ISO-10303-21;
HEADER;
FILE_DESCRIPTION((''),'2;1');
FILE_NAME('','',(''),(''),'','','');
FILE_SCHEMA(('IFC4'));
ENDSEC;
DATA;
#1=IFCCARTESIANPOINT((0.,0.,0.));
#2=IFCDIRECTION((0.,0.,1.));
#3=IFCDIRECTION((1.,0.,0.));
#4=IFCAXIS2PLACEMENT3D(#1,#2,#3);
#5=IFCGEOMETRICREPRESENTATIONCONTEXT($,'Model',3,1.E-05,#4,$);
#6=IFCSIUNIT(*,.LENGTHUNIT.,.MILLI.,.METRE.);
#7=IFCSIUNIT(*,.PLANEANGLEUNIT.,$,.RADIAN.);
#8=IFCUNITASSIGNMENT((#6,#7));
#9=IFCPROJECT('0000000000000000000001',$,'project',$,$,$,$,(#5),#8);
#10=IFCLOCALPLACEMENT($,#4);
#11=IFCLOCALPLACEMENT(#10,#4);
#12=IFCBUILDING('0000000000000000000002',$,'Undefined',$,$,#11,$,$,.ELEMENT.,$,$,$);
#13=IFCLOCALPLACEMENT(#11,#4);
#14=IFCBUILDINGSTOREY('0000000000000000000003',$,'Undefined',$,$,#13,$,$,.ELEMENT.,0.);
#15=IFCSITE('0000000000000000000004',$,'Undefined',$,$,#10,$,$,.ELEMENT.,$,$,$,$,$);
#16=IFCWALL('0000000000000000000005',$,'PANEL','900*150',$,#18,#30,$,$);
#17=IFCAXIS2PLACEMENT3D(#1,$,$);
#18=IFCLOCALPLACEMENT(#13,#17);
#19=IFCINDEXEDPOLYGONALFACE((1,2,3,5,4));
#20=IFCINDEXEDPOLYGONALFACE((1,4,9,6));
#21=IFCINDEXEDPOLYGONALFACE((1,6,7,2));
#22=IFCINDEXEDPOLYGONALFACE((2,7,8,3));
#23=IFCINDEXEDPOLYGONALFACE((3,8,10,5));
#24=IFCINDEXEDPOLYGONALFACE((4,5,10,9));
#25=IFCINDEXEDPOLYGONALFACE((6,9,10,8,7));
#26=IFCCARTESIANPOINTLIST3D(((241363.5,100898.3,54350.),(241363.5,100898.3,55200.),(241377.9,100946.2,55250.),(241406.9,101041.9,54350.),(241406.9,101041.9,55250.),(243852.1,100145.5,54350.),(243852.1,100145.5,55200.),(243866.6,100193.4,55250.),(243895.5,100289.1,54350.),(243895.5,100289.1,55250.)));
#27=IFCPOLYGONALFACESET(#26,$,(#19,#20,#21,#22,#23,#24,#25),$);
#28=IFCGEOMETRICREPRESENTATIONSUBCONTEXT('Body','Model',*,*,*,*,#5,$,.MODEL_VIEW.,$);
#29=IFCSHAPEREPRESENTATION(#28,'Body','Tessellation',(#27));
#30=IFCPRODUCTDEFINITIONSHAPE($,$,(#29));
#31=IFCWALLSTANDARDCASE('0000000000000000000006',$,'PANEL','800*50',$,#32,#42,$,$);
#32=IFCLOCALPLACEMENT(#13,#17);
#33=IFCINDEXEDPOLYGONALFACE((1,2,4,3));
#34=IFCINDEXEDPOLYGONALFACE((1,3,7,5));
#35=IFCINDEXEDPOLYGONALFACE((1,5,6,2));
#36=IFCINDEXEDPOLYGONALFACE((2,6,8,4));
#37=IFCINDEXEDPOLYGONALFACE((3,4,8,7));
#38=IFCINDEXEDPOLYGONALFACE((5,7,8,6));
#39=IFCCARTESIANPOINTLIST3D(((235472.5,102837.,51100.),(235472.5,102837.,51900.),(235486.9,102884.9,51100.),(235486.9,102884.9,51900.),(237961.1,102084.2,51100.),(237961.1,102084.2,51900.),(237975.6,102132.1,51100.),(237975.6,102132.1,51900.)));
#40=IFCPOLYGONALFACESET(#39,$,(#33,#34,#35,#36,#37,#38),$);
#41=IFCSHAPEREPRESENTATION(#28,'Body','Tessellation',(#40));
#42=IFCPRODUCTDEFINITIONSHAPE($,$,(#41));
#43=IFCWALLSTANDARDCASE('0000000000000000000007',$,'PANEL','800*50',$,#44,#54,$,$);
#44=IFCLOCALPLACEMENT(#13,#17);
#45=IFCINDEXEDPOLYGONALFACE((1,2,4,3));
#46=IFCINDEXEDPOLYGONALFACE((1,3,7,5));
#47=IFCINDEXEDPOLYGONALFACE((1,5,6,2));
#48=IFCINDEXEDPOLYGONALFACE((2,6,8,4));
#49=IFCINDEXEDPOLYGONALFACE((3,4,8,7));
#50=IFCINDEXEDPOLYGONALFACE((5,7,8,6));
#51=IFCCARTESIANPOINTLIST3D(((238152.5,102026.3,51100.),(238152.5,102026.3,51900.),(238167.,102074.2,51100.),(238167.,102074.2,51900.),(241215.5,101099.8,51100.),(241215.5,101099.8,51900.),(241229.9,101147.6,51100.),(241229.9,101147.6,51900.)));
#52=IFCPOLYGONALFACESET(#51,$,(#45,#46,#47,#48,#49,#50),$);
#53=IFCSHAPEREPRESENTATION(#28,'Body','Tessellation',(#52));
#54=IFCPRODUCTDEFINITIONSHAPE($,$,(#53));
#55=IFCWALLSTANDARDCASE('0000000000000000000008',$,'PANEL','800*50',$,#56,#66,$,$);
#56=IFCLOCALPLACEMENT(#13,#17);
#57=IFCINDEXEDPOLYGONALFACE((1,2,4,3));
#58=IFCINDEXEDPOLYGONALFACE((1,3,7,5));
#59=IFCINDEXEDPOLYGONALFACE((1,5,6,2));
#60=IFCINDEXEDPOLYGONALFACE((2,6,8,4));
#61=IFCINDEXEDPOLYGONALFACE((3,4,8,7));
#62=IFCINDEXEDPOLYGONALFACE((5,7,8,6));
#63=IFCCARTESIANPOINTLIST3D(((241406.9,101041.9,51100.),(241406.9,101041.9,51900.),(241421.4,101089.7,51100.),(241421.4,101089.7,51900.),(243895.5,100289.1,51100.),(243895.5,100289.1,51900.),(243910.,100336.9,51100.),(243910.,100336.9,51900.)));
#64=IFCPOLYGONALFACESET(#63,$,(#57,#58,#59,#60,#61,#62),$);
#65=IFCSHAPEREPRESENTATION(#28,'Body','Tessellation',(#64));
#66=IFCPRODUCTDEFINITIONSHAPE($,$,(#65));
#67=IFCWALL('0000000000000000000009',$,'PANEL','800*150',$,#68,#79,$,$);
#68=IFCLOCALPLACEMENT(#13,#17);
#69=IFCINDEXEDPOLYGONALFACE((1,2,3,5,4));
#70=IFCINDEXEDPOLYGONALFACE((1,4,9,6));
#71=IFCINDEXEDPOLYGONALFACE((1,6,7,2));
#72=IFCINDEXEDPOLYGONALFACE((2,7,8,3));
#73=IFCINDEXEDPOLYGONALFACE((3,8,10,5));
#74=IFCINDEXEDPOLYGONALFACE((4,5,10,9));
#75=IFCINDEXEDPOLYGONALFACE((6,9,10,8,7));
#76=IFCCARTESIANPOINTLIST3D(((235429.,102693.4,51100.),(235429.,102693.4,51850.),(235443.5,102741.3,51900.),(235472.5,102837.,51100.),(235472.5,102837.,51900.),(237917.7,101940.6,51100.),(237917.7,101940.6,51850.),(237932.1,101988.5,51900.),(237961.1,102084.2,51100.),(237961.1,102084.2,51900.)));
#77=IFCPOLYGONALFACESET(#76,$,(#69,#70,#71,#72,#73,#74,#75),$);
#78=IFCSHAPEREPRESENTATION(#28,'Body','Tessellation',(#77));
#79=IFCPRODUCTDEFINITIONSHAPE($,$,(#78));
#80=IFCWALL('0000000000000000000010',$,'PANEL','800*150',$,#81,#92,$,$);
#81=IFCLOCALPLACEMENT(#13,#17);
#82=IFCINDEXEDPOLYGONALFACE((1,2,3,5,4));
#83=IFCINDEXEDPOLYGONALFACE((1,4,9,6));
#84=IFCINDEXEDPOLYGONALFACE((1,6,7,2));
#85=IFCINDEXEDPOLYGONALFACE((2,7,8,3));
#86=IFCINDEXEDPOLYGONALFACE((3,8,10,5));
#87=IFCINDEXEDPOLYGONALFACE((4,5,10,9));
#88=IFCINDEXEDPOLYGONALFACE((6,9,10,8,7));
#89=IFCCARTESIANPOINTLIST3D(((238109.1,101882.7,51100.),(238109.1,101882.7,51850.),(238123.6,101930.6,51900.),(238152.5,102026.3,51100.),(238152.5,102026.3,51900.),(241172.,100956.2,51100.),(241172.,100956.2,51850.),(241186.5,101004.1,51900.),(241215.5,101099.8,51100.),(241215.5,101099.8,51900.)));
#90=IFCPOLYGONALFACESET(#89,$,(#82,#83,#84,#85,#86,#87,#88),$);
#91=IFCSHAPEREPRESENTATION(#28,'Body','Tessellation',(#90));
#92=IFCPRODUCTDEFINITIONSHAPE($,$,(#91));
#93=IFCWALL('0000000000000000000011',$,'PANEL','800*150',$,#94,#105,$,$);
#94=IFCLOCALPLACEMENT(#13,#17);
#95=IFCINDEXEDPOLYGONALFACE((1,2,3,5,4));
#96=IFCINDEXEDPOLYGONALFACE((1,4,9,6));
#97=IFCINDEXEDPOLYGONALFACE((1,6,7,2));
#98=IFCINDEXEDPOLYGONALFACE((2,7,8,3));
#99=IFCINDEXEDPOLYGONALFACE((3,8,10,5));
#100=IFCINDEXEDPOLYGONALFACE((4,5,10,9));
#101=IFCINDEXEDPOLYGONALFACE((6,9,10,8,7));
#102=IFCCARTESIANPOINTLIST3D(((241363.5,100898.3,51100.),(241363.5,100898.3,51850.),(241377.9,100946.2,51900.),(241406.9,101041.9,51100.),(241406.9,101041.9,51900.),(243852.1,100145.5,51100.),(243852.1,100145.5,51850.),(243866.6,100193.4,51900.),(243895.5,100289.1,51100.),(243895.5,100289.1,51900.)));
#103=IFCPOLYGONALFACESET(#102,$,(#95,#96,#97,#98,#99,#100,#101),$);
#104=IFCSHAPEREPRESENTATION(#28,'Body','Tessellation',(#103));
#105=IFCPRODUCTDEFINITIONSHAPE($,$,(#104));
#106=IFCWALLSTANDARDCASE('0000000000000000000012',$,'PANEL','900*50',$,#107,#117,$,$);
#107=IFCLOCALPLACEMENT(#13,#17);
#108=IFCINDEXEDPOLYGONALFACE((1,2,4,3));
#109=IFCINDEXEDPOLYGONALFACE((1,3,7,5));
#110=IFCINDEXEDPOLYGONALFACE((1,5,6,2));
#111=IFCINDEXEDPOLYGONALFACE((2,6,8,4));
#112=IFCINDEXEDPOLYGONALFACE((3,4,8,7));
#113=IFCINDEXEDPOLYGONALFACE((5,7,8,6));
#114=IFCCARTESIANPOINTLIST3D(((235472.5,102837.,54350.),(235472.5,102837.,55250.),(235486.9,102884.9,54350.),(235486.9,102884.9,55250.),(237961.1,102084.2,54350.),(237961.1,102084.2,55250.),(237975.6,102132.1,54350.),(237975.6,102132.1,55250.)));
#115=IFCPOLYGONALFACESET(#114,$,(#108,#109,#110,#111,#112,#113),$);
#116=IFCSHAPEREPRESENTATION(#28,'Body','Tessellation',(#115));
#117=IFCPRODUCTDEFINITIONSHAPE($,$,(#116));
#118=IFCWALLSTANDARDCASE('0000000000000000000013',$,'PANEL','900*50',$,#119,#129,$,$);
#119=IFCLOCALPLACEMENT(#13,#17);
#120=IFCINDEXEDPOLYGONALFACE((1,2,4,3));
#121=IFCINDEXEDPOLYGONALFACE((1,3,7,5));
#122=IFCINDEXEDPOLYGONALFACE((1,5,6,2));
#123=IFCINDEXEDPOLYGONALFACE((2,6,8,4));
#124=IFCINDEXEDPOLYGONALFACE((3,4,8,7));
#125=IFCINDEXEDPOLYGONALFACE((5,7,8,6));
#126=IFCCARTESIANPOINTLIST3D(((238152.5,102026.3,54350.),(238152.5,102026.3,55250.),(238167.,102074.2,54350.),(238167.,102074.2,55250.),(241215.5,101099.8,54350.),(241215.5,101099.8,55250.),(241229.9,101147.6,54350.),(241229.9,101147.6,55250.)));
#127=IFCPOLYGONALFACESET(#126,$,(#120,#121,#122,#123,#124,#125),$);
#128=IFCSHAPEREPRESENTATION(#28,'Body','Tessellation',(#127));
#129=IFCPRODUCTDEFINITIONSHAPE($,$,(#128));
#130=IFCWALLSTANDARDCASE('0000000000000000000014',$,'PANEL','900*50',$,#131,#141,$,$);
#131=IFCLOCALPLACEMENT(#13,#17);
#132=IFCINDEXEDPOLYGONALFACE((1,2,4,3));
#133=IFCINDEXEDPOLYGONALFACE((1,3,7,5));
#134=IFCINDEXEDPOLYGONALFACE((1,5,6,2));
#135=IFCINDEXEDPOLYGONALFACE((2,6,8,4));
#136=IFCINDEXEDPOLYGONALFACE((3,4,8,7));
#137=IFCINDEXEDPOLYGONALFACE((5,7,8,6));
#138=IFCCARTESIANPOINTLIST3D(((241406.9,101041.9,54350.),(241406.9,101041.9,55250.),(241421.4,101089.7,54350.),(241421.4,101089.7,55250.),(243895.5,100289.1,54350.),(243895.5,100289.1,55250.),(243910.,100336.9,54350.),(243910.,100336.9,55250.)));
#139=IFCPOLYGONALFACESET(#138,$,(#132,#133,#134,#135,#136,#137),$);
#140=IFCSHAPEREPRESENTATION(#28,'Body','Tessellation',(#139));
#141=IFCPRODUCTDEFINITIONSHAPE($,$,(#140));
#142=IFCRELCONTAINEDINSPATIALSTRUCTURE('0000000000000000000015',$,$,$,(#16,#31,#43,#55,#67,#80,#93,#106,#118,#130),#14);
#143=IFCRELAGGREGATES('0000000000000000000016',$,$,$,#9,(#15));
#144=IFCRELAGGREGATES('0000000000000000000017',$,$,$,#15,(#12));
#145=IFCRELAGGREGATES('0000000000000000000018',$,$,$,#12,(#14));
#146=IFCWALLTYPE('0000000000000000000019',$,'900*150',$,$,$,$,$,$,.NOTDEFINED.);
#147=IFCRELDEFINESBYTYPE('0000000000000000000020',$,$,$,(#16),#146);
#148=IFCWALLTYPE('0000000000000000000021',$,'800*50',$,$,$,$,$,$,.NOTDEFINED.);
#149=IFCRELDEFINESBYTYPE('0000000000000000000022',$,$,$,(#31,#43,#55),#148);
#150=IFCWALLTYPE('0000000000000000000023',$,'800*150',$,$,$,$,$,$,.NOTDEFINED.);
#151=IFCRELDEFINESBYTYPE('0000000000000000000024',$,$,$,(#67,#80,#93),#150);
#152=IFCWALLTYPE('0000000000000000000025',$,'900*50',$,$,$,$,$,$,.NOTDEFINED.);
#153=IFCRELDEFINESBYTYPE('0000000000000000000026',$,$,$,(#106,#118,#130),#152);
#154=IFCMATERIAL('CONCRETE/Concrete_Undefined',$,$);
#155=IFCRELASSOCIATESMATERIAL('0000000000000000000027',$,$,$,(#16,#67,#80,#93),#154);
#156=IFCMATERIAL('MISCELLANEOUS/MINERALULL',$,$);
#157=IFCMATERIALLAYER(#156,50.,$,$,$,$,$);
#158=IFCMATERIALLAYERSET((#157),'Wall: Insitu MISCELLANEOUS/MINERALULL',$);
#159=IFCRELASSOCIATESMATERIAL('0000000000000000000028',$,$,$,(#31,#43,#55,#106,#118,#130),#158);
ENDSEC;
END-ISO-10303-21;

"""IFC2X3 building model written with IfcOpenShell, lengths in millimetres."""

from ifc_helpers import new_model, si_unit, frame, frame_2d, origin_with_axes, place, context, subcontext, project, spatial, rectangle, extrude, clip, halfspace, material, layer, layer_set, layer_usage, type_object, element, save


model = new_model("IFC2X3")

# Units and contexts
model_context = context("Model", 3, precision=1e-05, world=origin_with_axes())
body_context = subcontext(model_context, "Body", "Model", "MODEL_VIEW")
ifc_project = project(units=[si_unit("LENGTHUNIT", "METRE", prefix="MILLI"), si_unit("PLANEANGLEUNIT", "RADIAN")], contexts=[model_context])

# Site, building, storey
site_placement = place(None, origin_with_axes())
site = spatial("IfcSite", under=ifc_project, at=site_placement, Name="Undefined", CompositionType="ELEMENT")
building_placement = place(site_placement, origin_with_axes())
building = spatial("IfcBuilding", under=site, at=building_placement, Name="Undefined", CompositionType="ELEMENT")
storey_placement = place(building_placement, origin_with_axes())
storey = spatial("IfcBuildingStorey", under=building, at=storey_placement, Name="Undefined", CompositionType="ELEMENT", Elevation=0.0)

# Shared definitions
ifc_material_1 = material(Name="CONCRETE/Concrete_Undefined")

# Walls
wall_type_1 = type_object("IfcWallType", Name="900*150", PredefinedType="NOTDEFINED")
wall_1_placement = place(storey_placement, frame((241385.2, 100970.1, 54350.0), z_axis=(0.0, 0.0, 1.0), x_axis=(0.957166, -0.289539, 0.0)))
element("IfcWall", 1, at=wall_1_placement, inside=storey, type_object=wall_type_1, material=ifc_material_1, Name="PANEL", Description="900*150", context=body_context, shape_type="Clipping", body=[
    clip(extrude(rectangle(XDim=2600.0, YDim=150.0, at=frame_2d((0.0, 1300.0), x_axis=(0.0, -1.0))), frame((0.0, 0.0, 0.0), z_axis=(0.0, 0.0, 1.0), x_axis=(0.0, -1.0, 0.0)), (0.0, 0.0, 1.0), 900.0), halfspace(frame((2600.0, 75.0, 1000.0), z_axis=(0.000001, -0.707072, 0.707141), x_axis=(0.0, -0.707141, -0.707072)), False)),
])
ifc_material_2 = material(Name="MISCELLANEOUS/MINERALULL")
ifc_layer = layer(ifc_material_2, 50.0)
ifc_layer_set = layer_set([ifc_layer], Name="Wall: Insitu MISCELLANEOUS/MINERALULL")
ifc_layer_usage_1 = layer_usage(ifc_layer_set, "AXIS2", "POSITIVE", -25.0)
wall_type_2 = type_object("IfcWallType", Name="800*50", PredefinedType="NOTDEFINED")
wall_2_placement = place(storey_placement, frame((235479.7, 102860.9, 51100.0), z_axis=(0.0, 0.0, 1.0), x_axis=(0.957166, -0.289539, 0.0)))
element("IfcWallStandardCase", 2, at=wall_2_placement, inside=storey, type_object=wall_type_2, material=ifc_layer_usage_1, Name="PANEL", Description="800*50", context=body_context, shape_type="SweptSolid", body=[
    extrude(rectangle(XDim=2600.0, YDim=50.0, at=frame_2d((0.0, 1300.0), x_axis=(0.0, -1.0))), frame((0.0, 0.0, 0.0), z_axis=(0.0, 0.0, 1.0), x_axis=(0.0, -1.0, 0.0)), (0.0, 0.0, 1.0), 800.0),
])
ifc_layer_usage_2 = layer_usage(ifc_layer_set, "AXIS2", "POSITIVE", -25.0)
wall_3_placement = place(storey_placement, frame((238159.8, 102050.2, 51100.0), z_axis=(0.0, 0.0, 1.0), x_axis=(0.957166, -0.289539, 0.0)))
element("IfcWallStandardCase", 3, at=wall_3_placement, inside=storey, type_object=wall_type_2, material=ifc_layer_usage_2, Name="PANEL", Description="800*50", context=body_context, shape_type="SweptSolid", body=[
    extrude(rectangle(XDim=3200.0, YDim=50.0, at=frame_2d((0.0, 1600.0), x_axis=(0.0, -1.0))), frame((0.0, 0.0, 0.0), z_axis=(0.0, 0.0, 1.0), x_axis=(0.0, -1.0, 0.0)), (0.0, 0.0, 1.0), 800.0),
])
ifc_layer_usage_3 = layer_usage(ifc_layer_set, "AXIS2", "POSITIVE", -25.0)
wall_4_placement = place(storey_placement, frame((241414.1, 101065.8, 51100.0), z_axis=(0.0, 0.0, 1.0), x_axis=(0.957166, -0.289539, 0.0)))
element("IfcWallStandardCase", 4, at=wall_4_placement, inside=storey, type_object=wall_type_2, material=ifc_layer_usage_3, Name="PANEL", Description="800*50", context=body_context, shape_type="SweptSolid", body=[
    extrude(rectangle(XDim=2600.0, YDim=50.0, at=frame_2d((0.0, 1300.0), x_axis=(0.0, -1.0))), frame((0.0, 0.0, 0.0), z_axis=(0.0, 0.0, 1.0), x_axis=(0.0, -1.0, 0.0)), (0.0, 0.0, 1.0), 800.0),
])
wall_type_3 = type_object("IfcWallType", Name="800*150", PredefinedType="NOTDEFINED")
wall_5_placement = place(storey_placement, frame((235450.7, 102765.2, 51100.0), z_axis=(0.0, 0.0, 1.0), x_axis=(0.957166, -0.289539, 0.0)))
element("IfcWall", 5, at=wall_5_placement, inside=storey, type_object=wall_type_3, material=ifc_material_1, Name="PANEL", Description="800*150", context=body_context, shape_type="Clipping", body=[
    clip(extrude(rectangle(XDim=2600.0, YDim=150.0, at=frame_2d((0.0, 1300.0), x_axis=(0.0, -1.0))), frame((0.0, 0.0, 0.0), z_axis=(0.0, 0.0, 1.0), x_axis=(0.0, -1.0, 0.0)), (0.0, 0.0, 1.0), 800.0), halfspace(frame((2600.0, 75.0, 900.0), z_axis=(0.000001, -0.707072, 0.707141), x_axis=(0.0, -0.707141, -0.707072)), False)),
])
wall_6_placement = place(storey_placement, frame((238130.8, 101954.5, 51100.0), z_axis=(0.0, 0.0, 1.0), x_axis=(0.957166, -0.289539, 0.0)))
element("IfcWall", 6, at=wall_6_placement, inside=storey, type_object=wall_type_3, material=ifc_material_1, Name="PANEL", Description="800*150", context=body_context, shape_type="Clipping", body=[
    clip(extrude(rectangle(XDim=3200.0, YDim=150.0, at=frame_2d((0.0, 1600.0), x_axis=(0.0, -1.0))), frame((0.0, 0.0, 0.0), z_axis=(0.0, 0.0, 1.0), x_axis=(0.0, -1.0, 0.0)), (0.0, 0.0, 1.0), 800.0), halfspace(frame((3200.0, 75.0, 900.0), z_axis=(0.000001, -0.707072, 0.707141), x_axis=(0.0, -0.707141, -0.707072)), False)),
])
wall_7_placement = place(storey_placement, frame((241385.2, 100970.1, 51100.0), z_axis=(0.0, 0.0, 1.0), x_axis=(0.957166, -0.289539, 0.0)))
element("IfcWall", 7, at=wall_7_placement, inside=storey, type_object=wall_type_3, material=ifc_material_1, Name="PANEL", Description="800*150", context=body_context, shape_type="Clipping", body=[
    clip(extrude(rectangle(XDim=2600.0, YDim=150.0, at=frame_2d((0.0, 1300.0), x_axis=(0.0, -1.0))), frame((0.0, 0.0, 0.0), z_axis=(0.0, 0.0, 1.0), x_axis=(0.0, -1.0, 0.0)), (0.0, 0.0, 1.0), 800.0), halfspace(frame((2600.0, 75.0, 900.0), z_axis=(0.000001, -0.707072, 0.707141), x_axis=(0.0, -0.707141, -0.707072)), False)),
])
ifc_layer_usage_4 = layer_usage(ifc_layer_set, "AXIS2", "POSITIVE", -25.0)
wall_type_4 = type_object("IfcWallType", Name="900*50", PredefinedType="NOTDEFINED")
wall_8_placement = place(storey_placement, frame((235479.7, 102860.9, 54350.0), z_axis=(0.0, 0.0, 1.0), x_axis=(0.957166, -0.289539, 0.0)))
element("IfcWallStandardCase", 8, at=wall_8_placement, inside=storey, type_object=wall_type_4, material=ifc_layer_usage_4, Name="PANEL", Description="900*50", context=body_context, shape_type="SweptSolid", body=[
    extrude(rectangle(XDim=2600.0, YDim=50.0, at=frame_2d((0.0, 1300.0), x_axis=(0.0, -1.0))), frame((0.0, 0.0, 0.0), z_axis=(0.0, 0.0, 1.0), x_axis=(0.0, -1.0, 0.0)), (0.0, 0.0, 1.0), 900.0),
])
ifc_layer_usage_5 = layer_usage(ifc_layer_set, "AXIS2", "POSITIVE", -25.0)
wall_9_placement = place(storey_placement, frame((238159.8, 102050.2, 54350.0), z_axis=(0.0, 0.0, 1.0), x_axis=(0.957166, -0.289539, 0.0)))
element("IfcWallStandardCase", 9, at=wall_9_placement, inside=storey, type_object=wall_type_4, material=ifc_layer_usage_5, Name="PANEL", Description="900*50", context=body_context, shape_type="SweptSolid", body=[
    extrude(rectangle(XDim=3200.0, YDim=50.0, at=frame_2d((0.0, 1600.0), x_axis=(0.0, -1.0))), frame((0.0, 0.0, 0.0), z_axis=(0.0, 0.0, 1.0), x_axis=(0.0, -1.0, 0.0)), (0.0, 0.0, 1.0), 900.0),
])
ifc_layer_usage_6 = layer_usage(ifc_layer_set, "AXIS2", "POSITIVE", -25.0)
wall_10_placement = place(storey_placement, frame((241414.1, 101065.8, 54350.0), z_axis=(0.0, 0.0, 1.0), x_axis=(0.957166, -0.289539, 0.0)))
element("IfcWallStandardCase", 10, at=wall_10_placement, inside=storey, type_object=wall_type_4, material=ifc_layer_usage_6, Name="PANEL", Description="900*50", context=body_context, shape_type="SweptSolid", body=[
    extrude(rectangle(XDim=2600.0, YDim=50.0, at=frame_2d((0.0, 1300.0), x_axis=(0.0, -1.0))), frame((0.0, 0.0, 0.0), z_axis=(0.0, 0.0, 1.0), x_axis=(0.0, -1.0, 0.0)), (0.0, 0.0, 1.0), 900.0),
])

save(model, "model.ifc")
